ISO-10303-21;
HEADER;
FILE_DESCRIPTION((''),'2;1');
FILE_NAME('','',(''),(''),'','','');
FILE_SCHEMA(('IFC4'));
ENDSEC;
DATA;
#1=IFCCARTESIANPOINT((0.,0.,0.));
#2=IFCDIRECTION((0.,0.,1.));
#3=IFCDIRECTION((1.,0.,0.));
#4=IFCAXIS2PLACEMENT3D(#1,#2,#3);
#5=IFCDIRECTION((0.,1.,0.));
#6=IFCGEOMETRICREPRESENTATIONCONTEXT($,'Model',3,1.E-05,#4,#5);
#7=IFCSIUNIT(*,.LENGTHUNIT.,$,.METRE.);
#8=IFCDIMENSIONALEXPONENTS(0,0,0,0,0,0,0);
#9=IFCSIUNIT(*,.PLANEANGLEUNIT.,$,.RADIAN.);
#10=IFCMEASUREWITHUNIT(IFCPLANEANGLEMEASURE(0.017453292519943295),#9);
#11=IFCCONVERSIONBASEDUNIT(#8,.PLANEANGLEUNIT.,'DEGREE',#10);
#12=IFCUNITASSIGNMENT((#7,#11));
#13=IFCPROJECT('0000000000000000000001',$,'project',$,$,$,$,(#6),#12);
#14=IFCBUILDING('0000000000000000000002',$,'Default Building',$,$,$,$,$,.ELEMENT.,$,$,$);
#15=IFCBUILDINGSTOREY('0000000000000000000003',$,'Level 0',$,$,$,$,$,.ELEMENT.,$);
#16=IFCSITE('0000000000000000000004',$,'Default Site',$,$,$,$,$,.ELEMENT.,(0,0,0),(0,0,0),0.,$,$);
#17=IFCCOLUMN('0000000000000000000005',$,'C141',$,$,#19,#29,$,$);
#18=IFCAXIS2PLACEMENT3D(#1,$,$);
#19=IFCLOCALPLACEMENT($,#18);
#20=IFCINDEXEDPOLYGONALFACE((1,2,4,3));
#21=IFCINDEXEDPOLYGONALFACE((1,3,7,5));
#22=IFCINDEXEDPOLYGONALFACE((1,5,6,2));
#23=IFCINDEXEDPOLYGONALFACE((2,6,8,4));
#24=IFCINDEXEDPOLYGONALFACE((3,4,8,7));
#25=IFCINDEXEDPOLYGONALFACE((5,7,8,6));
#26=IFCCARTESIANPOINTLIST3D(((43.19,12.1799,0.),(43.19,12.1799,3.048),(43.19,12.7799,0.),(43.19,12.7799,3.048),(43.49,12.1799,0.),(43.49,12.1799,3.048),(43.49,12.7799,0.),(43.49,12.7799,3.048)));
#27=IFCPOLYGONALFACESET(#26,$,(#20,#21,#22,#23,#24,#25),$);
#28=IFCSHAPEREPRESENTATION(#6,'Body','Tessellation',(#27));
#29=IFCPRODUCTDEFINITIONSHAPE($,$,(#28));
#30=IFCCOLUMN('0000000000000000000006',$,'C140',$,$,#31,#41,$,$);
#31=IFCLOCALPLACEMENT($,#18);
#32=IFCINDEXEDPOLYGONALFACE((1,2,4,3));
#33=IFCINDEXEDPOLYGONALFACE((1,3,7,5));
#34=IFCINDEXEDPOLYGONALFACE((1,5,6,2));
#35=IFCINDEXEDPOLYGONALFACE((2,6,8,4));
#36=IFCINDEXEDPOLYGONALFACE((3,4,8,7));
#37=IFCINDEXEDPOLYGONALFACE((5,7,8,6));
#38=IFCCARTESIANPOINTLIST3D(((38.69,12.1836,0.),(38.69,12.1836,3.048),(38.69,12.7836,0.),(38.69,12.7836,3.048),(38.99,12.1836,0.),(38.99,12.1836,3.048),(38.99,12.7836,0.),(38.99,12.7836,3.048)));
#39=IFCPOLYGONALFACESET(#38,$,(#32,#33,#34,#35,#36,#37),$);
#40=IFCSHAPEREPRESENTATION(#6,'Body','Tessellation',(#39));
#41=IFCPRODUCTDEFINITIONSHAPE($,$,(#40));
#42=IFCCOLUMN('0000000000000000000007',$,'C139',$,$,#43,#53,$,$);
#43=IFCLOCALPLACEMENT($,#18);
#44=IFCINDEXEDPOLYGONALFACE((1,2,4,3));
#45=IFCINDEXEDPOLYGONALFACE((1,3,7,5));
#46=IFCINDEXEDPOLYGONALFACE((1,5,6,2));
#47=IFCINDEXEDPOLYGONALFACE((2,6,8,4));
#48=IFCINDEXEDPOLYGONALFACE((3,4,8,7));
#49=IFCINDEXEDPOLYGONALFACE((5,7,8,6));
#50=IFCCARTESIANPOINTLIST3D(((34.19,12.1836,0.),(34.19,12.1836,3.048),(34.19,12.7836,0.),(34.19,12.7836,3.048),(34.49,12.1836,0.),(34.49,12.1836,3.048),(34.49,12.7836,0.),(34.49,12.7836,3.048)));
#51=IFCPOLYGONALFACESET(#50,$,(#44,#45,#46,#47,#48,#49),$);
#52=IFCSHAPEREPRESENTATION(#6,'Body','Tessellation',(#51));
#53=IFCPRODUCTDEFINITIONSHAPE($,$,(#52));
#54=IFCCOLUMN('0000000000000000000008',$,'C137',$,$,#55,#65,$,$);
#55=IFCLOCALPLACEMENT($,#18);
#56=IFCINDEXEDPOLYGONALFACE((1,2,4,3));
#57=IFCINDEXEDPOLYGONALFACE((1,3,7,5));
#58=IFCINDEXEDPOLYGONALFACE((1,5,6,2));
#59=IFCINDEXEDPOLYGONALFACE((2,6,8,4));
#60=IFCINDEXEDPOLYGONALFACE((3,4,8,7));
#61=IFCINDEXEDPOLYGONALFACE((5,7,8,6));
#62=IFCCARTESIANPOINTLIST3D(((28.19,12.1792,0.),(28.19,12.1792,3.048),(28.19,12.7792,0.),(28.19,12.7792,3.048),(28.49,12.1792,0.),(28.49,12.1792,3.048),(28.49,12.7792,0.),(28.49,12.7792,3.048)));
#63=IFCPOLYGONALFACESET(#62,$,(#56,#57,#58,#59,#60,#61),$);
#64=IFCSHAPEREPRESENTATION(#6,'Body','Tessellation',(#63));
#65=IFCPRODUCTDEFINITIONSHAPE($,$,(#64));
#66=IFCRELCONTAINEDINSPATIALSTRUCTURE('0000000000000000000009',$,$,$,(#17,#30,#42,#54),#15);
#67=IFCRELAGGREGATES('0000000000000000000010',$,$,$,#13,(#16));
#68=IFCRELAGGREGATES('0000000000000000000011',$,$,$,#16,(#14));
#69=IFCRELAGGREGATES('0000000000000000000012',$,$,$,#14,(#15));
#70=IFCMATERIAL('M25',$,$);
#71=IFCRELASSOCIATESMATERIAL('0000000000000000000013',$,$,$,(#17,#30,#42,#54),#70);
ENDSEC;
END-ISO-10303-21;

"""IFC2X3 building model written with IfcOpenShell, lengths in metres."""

from ifc_helpers import new_model, entity, si_unit, converted_unit, direction, frame, frame_2d, origin_with_axes, place, context, project, spatial, rectangle, extrude, material, element, save


model = new_model("IFC2X3")

# Units and contexts
model_context = context("Model", 3, precision=1e-05, world=origin_with_axes(), true_north=direction((0.0, 1.0, 0.0)))
ifc_project = project(units=[si_unit("LENGTHUNIT", "METRE"), converted_unit("PLANEANGLEUNIT", "DEGREE", entity("IfcPlaneAngleMeasure", 0.017453292519943295), si_unit("PLANEANGLEUNIT", "RADIAN"), dimensions=[0, 0, 0, 0, 0, 0, 0])], contexts=[model_context])

# Site, building, storey
site = spatial("IfcSite", under=ifc_project, Name="Default Site", CompositionType="ELEMENT", RefLatitude=(0, 0, 0), RefLongitude=(0, 0, 0), RefElevation=0.0)
building = spatial("IfcBuilding", under=site, Name="Default Building", CompositionType="ELEMENT")
storey = spatial("IfcBuildingStorey", under=building, Name="Level 0", CompositionType="ELEMENT")

# Columns
ifc_material = material(Name="M25")
placement = place(None, origin_with_axes())
element("IfcColumn", 1, at=placement, inside=storey, material=ifc_material, Name="C141", context=model_context, shape_type="SweptSolid", body=[
    extrude(rectangle(XDim=0.3, YDim=0.6, at=frame_2d((0.0, 0.0), x_axis=(1.0, 0.0, 0.0))), frame((43.34, 12.4799, 0.0), z_axis=(0.0, 0.0, 1.0), x_axis=(1.0, 0.0, 0.0)), (0.0, 0.0, 1.0), 3.048),
])
element("IfcColumn", 2, at=placement, inside=storey, material=ifc_material, Name="C140", context=model_context, shape_type="SweptSolid", body=[
    extrude(rectangle(XDim=0.3, YDim=0.6, at=frame_2d((0.0, 0.0), x_axis=(1.0, 0.0, 0.0))), frame((38.84, 12.4836, 0.0), z_axis=(0.0, 0.0, 1.0), x_axis=(1.0, 0.0, 0.0)), (0.0, 0.0, 1.0), 3.048),
])
element("IfcColumn", 3, at=placement, inside=storey, material=ifc_material, Name="C139", context=model_context, shape_type="SweptSolid", body=[
    extrude(rectangle(XDim=0.3, YDim=0.6, at=frame_2d((0.0, 0.0), x_axis=(1.0, 0.0, 0.0))), frame((34.34, 12.4836, 0.0), z_axis=(0.0, 0.0, 1.0), x_axis=(1.0, 0.0, 0.0)), (0.0, 0.0, 1.0), 3.048),
])
element("IfcColumn", 4, at=placement, inside=storey, material=ifc_material, Name="C137", context=model_context, shape_type="SweptSolid", body=[
    extrude(rectangle(XDim=0.3, YDim=0.6, at=frame_2d((0.0, 0.0), x_axis=(1.0, 0.0, 0.0))), frame((28.34, 12.4792, 0.0), z_axis=(0.0, 0.0, 1.0), x_axis=(1.0, 0.0, 0.0)), (0.0, 0.0, 1.0), 3.048),
])

save(model, "model.ifc")
